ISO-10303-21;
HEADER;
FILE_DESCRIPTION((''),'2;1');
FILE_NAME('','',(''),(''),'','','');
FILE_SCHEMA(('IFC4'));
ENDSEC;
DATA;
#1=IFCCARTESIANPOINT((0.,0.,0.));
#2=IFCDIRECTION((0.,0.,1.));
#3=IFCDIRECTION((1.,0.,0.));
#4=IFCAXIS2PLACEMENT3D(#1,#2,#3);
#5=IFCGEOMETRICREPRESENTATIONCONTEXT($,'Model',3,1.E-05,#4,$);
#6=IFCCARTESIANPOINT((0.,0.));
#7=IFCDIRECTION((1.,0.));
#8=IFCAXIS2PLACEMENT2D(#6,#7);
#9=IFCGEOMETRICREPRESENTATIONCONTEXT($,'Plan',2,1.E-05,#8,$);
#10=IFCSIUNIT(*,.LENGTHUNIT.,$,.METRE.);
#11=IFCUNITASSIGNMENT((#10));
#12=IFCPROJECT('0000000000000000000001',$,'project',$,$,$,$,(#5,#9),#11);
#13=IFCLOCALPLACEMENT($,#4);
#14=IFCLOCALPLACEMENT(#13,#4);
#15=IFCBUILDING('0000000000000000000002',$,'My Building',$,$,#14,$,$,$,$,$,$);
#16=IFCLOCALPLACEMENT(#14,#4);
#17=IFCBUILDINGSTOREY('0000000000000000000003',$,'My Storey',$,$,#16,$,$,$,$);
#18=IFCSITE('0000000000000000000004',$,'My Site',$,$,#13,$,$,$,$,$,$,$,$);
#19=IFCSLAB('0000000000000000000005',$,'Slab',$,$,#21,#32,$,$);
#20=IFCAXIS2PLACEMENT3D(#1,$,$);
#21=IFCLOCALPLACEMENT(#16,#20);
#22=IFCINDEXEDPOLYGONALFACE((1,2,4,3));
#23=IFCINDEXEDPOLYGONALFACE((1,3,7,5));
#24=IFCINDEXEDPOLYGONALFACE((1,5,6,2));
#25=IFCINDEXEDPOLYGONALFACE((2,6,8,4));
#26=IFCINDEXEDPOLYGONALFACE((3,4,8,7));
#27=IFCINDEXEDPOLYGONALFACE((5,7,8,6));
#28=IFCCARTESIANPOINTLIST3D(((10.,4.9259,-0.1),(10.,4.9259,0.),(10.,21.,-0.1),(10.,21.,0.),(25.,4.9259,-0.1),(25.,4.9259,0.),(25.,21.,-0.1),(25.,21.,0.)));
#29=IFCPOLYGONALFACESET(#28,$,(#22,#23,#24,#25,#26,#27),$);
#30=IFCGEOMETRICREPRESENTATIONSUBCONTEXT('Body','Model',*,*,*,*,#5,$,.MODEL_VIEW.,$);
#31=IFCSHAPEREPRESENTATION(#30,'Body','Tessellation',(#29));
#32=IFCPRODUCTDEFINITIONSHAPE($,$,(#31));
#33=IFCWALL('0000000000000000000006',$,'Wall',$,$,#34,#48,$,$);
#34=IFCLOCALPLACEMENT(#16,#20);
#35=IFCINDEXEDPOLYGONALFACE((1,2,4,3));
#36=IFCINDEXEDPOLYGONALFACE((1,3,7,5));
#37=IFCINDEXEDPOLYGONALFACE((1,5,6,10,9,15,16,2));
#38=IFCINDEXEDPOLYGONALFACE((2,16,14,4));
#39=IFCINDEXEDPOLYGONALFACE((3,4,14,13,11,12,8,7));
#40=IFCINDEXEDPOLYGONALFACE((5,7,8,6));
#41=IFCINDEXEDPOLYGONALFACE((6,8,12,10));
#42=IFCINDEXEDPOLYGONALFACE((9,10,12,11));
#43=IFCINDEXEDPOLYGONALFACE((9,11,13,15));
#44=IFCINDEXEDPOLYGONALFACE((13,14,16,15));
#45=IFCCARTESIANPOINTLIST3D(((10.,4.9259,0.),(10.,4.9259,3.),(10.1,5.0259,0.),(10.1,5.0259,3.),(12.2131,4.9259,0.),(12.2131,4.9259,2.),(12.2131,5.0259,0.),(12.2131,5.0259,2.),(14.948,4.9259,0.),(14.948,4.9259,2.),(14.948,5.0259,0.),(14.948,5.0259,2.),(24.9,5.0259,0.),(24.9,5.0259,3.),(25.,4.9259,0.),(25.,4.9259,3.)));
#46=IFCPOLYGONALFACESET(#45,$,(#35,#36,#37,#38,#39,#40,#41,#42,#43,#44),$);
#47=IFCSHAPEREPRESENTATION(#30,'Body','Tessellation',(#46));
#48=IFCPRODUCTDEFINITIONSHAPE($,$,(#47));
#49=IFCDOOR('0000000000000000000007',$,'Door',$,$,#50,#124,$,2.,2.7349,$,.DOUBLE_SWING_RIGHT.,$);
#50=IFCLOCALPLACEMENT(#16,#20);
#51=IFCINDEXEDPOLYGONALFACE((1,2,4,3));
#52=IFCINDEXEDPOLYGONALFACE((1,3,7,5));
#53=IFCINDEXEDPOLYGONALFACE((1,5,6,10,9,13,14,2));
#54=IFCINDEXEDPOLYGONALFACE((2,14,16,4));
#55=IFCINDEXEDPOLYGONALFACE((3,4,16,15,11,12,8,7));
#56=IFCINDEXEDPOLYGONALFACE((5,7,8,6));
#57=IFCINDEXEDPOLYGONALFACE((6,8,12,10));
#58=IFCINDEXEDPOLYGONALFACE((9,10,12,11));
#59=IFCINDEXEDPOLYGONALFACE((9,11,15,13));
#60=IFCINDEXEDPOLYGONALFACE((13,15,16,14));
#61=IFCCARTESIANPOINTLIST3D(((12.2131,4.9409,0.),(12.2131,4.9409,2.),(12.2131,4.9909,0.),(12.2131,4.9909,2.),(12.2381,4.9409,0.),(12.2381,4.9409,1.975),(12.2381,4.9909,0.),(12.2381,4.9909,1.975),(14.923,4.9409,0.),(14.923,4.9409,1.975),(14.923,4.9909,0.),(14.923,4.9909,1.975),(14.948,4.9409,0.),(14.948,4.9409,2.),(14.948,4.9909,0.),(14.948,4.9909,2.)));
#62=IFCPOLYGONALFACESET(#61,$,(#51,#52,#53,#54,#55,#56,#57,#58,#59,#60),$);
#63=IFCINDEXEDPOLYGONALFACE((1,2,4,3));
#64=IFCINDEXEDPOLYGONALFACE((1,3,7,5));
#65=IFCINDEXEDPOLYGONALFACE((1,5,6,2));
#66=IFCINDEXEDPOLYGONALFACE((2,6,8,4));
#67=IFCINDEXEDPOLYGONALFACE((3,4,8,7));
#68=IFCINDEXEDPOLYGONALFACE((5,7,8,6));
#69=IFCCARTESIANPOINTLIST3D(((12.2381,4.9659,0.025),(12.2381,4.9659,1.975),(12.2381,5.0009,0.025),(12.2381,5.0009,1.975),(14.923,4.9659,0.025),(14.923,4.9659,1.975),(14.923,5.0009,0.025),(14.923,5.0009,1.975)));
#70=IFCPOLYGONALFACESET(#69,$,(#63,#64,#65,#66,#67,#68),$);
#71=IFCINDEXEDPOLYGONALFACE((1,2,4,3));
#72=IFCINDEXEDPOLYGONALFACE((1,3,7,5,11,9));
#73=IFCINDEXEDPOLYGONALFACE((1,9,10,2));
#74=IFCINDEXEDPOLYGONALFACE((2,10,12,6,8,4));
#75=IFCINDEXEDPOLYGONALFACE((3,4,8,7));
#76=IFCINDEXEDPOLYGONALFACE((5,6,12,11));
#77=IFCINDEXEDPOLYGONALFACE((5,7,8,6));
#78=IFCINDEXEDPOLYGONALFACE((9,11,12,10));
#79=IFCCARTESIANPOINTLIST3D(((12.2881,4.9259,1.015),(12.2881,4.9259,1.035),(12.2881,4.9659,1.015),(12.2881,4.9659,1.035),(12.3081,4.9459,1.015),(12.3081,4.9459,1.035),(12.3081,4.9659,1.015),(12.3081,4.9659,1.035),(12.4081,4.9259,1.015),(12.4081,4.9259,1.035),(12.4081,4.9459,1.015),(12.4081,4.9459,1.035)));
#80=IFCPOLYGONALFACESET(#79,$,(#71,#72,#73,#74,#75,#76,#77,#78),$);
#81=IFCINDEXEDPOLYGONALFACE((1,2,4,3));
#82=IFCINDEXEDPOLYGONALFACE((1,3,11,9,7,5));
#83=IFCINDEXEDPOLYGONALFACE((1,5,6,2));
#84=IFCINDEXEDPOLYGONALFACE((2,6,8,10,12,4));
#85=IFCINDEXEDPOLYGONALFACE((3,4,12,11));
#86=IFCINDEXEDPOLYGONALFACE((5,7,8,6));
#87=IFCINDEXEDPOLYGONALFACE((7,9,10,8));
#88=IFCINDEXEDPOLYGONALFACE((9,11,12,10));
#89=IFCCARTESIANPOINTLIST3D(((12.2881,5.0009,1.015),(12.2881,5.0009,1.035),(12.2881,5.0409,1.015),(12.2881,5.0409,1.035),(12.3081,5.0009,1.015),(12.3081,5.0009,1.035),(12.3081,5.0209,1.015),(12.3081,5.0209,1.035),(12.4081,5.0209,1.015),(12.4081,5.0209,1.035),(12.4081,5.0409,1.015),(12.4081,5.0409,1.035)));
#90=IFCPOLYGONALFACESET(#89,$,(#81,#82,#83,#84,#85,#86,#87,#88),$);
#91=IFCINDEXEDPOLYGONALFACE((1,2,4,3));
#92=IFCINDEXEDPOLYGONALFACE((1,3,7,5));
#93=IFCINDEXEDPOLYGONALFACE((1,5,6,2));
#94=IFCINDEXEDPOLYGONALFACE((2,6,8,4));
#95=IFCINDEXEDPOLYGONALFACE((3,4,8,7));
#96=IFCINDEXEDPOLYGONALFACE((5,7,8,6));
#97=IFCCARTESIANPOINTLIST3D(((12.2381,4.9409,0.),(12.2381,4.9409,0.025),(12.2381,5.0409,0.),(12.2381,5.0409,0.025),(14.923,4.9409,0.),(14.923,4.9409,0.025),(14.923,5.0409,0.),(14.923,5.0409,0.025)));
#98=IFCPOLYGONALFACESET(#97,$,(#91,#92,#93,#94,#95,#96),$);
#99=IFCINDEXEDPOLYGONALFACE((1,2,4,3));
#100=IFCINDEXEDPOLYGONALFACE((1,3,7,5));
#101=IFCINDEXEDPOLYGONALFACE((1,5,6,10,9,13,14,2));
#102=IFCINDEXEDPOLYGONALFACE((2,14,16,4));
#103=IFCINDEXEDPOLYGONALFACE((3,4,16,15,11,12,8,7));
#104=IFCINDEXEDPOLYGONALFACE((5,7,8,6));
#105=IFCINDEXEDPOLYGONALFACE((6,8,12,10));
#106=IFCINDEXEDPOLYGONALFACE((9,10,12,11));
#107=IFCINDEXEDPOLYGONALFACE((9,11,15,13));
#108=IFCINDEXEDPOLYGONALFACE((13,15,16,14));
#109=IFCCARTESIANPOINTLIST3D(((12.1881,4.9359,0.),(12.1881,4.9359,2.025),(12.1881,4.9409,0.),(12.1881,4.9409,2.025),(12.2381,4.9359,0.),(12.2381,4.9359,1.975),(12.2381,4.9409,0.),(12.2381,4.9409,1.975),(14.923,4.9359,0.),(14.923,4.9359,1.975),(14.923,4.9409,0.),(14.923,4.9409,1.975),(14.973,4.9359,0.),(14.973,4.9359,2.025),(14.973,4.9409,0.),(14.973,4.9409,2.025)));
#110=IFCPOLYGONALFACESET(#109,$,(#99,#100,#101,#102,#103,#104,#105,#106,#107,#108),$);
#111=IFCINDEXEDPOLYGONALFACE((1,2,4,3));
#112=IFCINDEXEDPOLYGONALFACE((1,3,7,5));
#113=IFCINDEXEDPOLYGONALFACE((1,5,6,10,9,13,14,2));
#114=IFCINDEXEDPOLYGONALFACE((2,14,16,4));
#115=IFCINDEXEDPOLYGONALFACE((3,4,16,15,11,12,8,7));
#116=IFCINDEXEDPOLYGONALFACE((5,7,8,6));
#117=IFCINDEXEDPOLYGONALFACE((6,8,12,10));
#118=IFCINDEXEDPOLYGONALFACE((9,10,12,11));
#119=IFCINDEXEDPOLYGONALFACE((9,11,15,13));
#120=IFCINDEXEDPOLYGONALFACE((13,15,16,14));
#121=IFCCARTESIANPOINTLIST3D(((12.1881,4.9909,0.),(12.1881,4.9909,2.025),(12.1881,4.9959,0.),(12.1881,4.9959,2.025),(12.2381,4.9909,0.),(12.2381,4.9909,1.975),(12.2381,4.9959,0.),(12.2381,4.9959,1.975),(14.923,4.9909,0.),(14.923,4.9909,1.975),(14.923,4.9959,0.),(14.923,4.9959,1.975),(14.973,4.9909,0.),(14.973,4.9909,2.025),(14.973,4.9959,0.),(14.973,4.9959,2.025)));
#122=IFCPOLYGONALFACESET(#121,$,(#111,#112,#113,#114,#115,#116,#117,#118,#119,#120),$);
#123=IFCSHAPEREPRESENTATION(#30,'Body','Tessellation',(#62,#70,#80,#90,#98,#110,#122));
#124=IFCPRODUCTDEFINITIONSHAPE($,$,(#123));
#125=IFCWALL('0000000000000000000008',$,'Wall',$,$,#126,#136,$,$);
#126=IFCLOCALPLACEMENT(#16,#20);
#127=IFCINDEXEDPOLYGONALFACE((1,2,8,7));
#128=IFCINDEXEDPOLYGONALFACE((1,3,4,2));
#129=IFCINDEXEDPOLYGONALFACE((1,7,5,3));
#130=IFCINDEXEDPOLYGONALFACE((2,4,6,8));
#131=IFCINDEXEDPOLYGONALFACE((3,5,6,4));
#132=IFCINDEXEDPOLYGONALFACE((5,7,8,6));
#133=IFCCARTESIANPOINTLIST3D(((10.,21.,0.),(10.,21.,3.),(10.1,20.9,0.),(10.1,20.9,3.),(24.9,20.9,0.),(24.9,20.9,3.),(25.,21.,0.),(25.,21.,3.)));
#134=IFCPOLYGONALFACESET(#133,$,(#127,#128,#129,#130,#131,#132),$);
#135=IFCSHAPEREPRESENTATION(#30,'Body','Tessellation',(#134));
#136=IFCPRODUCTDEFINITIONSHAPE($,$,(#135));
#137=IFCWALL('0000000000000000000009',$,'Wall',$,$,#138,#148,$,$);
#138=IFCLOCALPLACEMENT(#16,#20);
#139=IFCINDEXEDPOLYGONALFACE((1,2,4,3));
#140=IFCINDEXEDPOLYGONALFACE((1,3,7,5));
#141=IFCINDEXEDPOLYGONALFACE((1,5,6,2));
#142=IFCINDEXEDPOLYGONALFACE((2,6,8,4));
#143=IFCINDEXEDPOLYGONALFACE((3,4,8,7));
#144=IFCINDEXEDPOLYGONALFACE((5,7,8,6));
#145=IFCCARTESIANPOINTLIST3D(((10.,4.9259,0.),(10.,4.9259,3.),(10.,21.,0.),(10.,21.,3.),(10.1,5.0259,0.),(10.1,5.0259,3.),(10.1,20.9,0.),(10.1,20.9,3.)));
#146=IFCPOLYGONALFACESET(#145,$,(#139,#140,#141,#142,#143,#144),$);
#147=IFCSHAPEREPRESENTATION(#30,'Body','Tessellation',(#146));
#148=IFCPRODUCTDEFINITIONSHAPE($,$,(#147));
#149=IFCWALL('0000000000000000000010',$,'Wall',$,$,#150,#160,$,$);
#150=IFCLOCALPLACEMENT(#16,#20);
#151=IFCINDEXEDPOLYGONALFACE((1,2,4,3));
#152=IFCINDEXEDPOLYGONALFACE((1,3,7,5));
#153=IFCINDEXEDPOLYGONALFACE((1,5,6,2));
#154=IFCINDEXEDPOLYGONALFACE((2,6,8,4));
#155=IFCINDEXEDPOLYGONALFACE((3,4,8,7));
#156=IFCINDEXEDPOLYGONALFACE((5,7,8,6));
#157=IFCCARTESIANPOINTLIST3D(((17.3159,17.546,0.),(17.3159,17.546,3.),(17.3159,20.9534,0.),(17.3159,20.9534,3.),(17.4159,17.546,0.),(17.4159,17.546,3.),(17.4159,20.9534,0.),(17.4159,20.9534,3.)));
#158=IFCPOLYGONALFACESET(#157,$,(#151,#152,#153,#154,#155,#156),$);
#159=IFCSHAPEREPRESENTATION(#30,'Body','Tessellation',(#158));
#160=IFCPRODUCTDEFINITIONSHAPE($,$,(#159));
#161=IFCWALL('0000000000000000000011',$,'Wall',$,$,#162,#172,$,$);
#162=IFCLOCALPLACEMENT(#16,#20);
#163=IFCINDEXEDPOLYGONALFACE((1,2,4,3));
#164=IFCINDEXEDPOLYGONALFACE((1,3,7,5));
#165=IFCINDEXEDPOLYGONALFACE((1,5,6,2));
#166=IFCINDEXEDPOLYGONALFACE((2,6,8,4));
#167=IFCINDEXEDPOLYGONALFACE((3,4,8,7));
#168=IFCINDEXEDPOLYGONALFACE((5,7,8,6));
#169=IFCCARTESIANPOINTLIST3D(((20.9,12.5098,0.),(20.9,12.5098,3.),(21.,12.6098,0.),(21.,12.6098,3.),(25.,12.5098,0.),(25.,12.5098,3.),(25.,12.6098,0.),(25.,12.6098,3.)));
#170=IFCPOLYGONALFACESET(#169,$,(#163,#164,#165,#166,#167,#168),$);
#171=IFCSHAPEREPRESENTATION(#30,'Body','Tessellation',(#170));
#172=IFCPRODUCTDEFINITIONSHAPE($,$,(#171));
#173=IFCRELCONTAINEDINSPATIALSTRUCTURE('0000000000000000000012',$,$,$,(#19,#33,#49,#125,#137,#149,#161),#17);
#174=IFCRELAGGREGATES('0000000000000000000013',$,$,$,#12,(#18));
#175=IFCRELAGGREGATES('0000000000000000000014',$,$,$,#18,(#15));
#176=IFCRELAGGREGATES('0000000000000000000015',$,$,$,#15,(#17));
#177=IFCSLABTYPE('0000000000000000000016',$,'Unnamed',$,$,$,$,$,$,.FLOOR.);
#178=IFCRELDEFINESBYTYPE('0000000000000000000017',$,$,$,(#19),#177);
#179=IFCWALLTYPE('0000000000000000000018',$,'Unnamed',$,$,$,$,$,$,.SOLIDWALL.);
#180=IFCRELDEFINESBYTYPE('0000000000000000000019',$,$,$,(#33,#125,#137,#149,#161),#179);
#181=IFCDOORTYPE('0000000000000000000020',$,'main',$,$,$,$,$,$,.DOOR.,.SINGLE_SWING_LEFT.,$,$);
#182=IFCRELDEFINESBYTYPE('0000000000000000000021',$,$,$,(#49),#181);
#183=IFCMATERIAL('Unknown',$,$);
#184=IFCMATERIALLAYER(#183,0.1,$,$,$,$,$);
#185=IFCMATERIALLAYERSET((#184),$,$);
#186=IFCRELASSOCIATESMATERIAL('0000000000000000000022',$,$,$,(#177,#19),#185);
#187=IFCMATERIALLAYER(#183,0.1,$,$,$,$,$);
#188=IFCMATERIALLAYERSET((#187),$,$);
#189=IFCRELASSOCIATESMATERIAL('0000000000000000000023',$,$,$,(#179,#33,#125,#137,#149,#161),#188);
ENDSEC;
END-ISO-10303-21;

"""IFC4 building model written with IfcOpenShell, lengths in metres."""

from ifc_helpers import new_model, entity, si_unit, frame, origin_with_axes, origin_2d_with_axis, place, context, subcontext, project, spatial, line, indexed_curve, outline, extrude, shape, source, transform, mapped, material, layer, layer_set, layer_usage, type_object, type_shapes, element, fill, save


model = new_model("IFC4")

# Units and contexts
model_context = context("Model", 3, precision=1e-05, world=origin_with_axes())
plan_context = context("Plan", 2, precision=1e-05, world=origin_2d_with_axis())
body_context_1 = subcontext(model_context, "Body", "Model", "MODEL_VIEW")
body_context_2 = subcontext(plan_context, "Body", "Plan", "PLAN_VIEW")
ifc_project = project(units=[si_unit("LENGTHUNIT", "METRE")], contexts=[model_context, plan_context])

# Site, building, storey
site_placement = place(None, origin_with_axes())
site = spatial("IfcSite", under=ifc_project, at=site_placement, Name="My Site")
building_placement = place(site_placement, origin_with_axes())
building = spatial("IfcBuilding", under=site, at=building_placement, Name="My Building")
storey_placement = place(building_placement, origin_with_axes())
storey = spatial("IfcBuildingStorey", under=building, at=storey_placement, Name="My Storey")

# Slab
ifc_material = material(Name="Unknown")
ifc_layer_1 = layer(ifc_material, 0.1)
ifc_layer_set_1 = layer_set([ifc_layer_1])
ifc_layer_usage_1 = layer_usage(ifc_layer_set_1, "AXIS3", "POSITIVE", -0.1)
slab_type = type_object("IfcSlabType", Name="Unnamed", PredefinedType="FLOOR", material=ifc_layer_set_1)
slab_placement = place(storey_placement, frame((10.0, 21.0, 0.0), z_axis=(0.0, 0.0, 1.0), x_axis=(1.0, 0.0, 0.0)))
element("IfcSlab", 1, at=slab_placement, inside=storey, type_object=slab_type, material=ifc_layer_usage_1, Name="Slab", context=body_context_1, shape_type="SweptSolid", body=[
    extrude(outline(indexed_curve([(0.0, -16.0741), (15.0, -16.0741), (15.0, 0.0), (0.0, 0.0), (0.0, -16.0741)])), frame((0.0, 0.0, -0.1), z_axis=(0.0, 0.0, 1.0), x_axis=(1.0, 0.0, 0.0)), (0.0, 0.0, 1.0), 0.1),
])

# Wall, opening, door
ifc_layer_2 = layer(ifc_material, 0.1)
ifc_layer_set_2 = layer_set([ifc_layer_2])
ifc_layer_usage_2 = layer_usage(ifc_layer_set_2, "AXIS2", "POSITIVE", 0.0)
wall_type = type_object("IfcWallType", Name="Unnamed", PredefinedType="SOLIDWALL", material=ifc_layer_set_2)
wall_1_placement = place(storey_placement, frame((10.0, 4.9259, 0.0), z_axis=(0.0, 0.0, 1.0), x_axis=(1.0, 0.0, 0.0)))
wall_1 = element("IfcWall", 2, at=wall_1_placement, inside=storey, type_object=wall_type, material=ifc_layer_usage_2, Name="Wall", context=body_context_1, shape_type="SweptSolid", body=[
    extrude(outline(indexed_curve([(0.0, 0.0), (0.1, 0.1), (14.9, 0.1), (15.0, 0.0)], segments=[line(1, 2, 3, 4, 1)])), origin_with_axes(), (0.0, 0.0, 1.0), 3.0),
])
shared_shape_1 = source(origin_with_axes(), body_context_1, "Body", "SweptSolid", [
    extrude(outline(indexed_curve([(0.0, 0.0), (2.7349, 0.0), (2.7349, 2.0), (0.0, 2.0)], segments=[line(1, 2, 3, 4, 1)])), frame((0.0, -0.6, 0.0), z_axis=(0.0, -1.0, 0.0), x_axis=(1.0, 0.0, 0.0)), (0.0, 0.0, -1.0), 1.2),
])
opening_1_placement = place(wall_1_placement, frame((2.2131, 0.015, 0.0), z_axis=(0.0, 0.0, 1.0), x_axis=(1.0, 0.0, 0.0)))
opening_1 = element("IfcOpeningElement", 3, at=opening_1_placement, cuts=wall_1, PredefinedType="OPENING", context=body_context_1, shape_type="MappedRepresentation", body=[
    mapped(shared_shape_1, transform((0.0, 0.0, 0.0), x_axis=(1.0, 0.0, 0.0), y_axis=(0.0, 1.0, 0.0), z_axis=(0.0, 0.0, 1.0), scale=1.0)),
])
door_type_1 = type_object("IfcDoorType", Name="main", OperationType="SINGLE_SWING_LEFT", PredefinedType="DOOR")
shared_shape_2 = source(origin_with_axes(), body_context_1, "Body", "SweptSolid", [
    extrude(outline(indexed_curve([(0.0, 0.0), (0.0, 2.0), (2.7349, 2.0), (2.7349, 0.0), (2.7099, 0.0), (2.7099, 1.975), (0.025, 1.975), (0.025, 0.0)], segments=[line(1, 2, 3, 4, 5, 6, 7, 8, 1)])), frame((0.0, 0.0, 0.0), z_axis=(0.0, -1.0, 0.0), x_axis=(1.0, 0.0, 0.0)), (0.0, 0.0, -1.0), 0.05),
    extrude(outline(indexed_curve([(0.0, 0.0), (2.6849, 0.0), (2.6849, 0.035), (0.0, 0.035)], segments=[line(1, 2, 3, 4, 1)])), frame((0.025, 0.025, 0.025), z_axis=(0.0, 0.0, 1.0), x_axis=(1.0, 0.0, 0.0)), (0.0, 0.0, 1.0), 1.95),
    extrude(outline(indexed_curve([(0.0, 0.0), (0.0, -0.04), (0.12, -0.04), (0.12, -0.02), (0.02, -0.02), (0.02, 0.0)], segments=[line(1, 2, 3, 4, 5, 6, 1)])), frame((0.075, 0.025, 1.015), z_axis=(0.0, 0.0, 1.0), x_axis=(1.0, 0.0, 0.0)), (0.0, 0.0, 1.0), 0.02),
    extrude(outline(indexed_curve([(0.0, 0.0), (0.0, 0.04), (0.12, 0.04), (0.12, 0.02), (0.02, 0.02), (0.02, 0.0)], segments=[line(1, 2, 3, 4, 5, 6, 1)])), frame((0.075, 0.06, 1.015), z_axis=(0.0, 0.0, 1.0), x_axis=(1.0, 0.0, 0.0)), (0.0, 0.0, 1.0), 0.02),
    extrude(outline(indexed_curve([(0.0, 0.0), (2.6849, 0.0), (2.6849, 0.1), (0.0, 0.1)], segments=[line(1, 2, 3, 4, 1)])), frame((0.025, 0.0, 0.0), z_axis=(0.0, 0.0, 1.0), x_axis=(1.0, 0.0, 0.0)), (0.0, 0.0, 1.0), 0.025),
    extrude(outline(indexed_curve([(0.0, 0.0), (0.0, 2.025), (2.7849, 2.025), (2.7849, 0.0), (2.7349, 0.0), (2.7349, 1.975), (0.05, 1.975), (0.05, 0.0)], segments=[line(1, 2, 3, 4, 5, 6, 7, 8, 1)])), frame((-0.025, -0.005, 0.0), z_axis=(0.0, -1.0, 0.0), x_axis=(1.0, 0.0, 0.0)), (0.0, 0.0, -1.0), 0.005),
    extrude(outline(indexed_curve([(0.0, 0.0), (0.0, 2.025), (2.7849, 2.025), (2.7849, 0.0), (2.7349, 0.0), (2.7349, 1.975), (0.05, 1.975), (0.05, 0.0)], segments=[line(1, 2, 3, 4, 5, 6, 7, 8, 1)])), frame((-0.025, 0.05, 0.0), z_axis=(0.0, -1.0, 0.0), x_axis=(1.0, 0.0, 0.0)), (0.0, 0.0, -1.0), 0.005),
])
shared_shape_3 = source(origin_with_axes(), body_context_2, "Body", "Curve2D", [
    entity("IfcIndexedPolyCurve", entity("IfcCartesianPointList2D", [[0.0, 0.0], [0.025, 0.0], [0.025, 0.05], [0.0, 0.05]]), [entity("IfcLineIndex", [1, 2, 3, 4, 1])]),
    entity("IfcIndexedPolyCurve", entity("IfcCartesianPointList2D", [[2.7349, 0.0], [2.7099, 0.0], [2.7099, 0.05], [2.7349, 0.05]]), [entity("IfcLineIndex", [1, 2, 3, 4, 1])]),
    entity("IfcIndexedPolyCurve", entity("IfcCartesianPointList2D", [[2.7099, 0.05], [2.7099, -2.6349], [2.6749, -2.6349]])),
    entity("IfcTrimmedCurve", entity("IfcEllipse", entity("IfcAxis2Placement2D", entity("IfcCartesianPoint", [2.6749, 0.05]), entity("IfcDirection", [1.0, 0.0])), 2.6499, 2.6849), [entity("IfcCartesianPoint", [2.6749, 2.7349])], [entity("IfcCartesianPoint", [2.6749, -2.6349])], True, "CARTESIAN"),
    entity("IfcIndexedPolyCurve", entity("IfcCartesianPointList2D", [[2.7099, 0.05], [2.6749, 0.05], [2.6749, 2.7349], [2.7099, 2.7349]]), [entity("IfcLineIndex", [1, 2, 3, 4, 1])]),
])
type_shapes(door_type_1, [shared_shape_2, shared_shape_3])
door_1_placement = place(opening_1_placement, frame((0.0, 0.0, 0.0), z_axis=(0.0, 0.0, 1.0), x_axis=(1.0, 0.0, 0.0)))
door_1 = element("IfcDoor", 4, at=door_1_placement, inside=storey, type_object=door_type_1, Name="Door", OperationType="DOUBLE_SWING_RIGHT", OverallHeight=2.0, OverallWidth=2.7349, shapes=[
    shape(body_context_1, "Body", "MappedRepresentation", [mapped(shared_shape_2, transform((0.0, 0.0, 0.0), x_axis=(1.0, 0.0, 0.0), y_axis=(0.0, 1.0, 0.0), z_axis=(0.0, 0.0, 1.0), scale=1.0))]),
    shape(body_context_2, "Body", "MappedRepresentation", [mapped(shared_shape_3, transform((0.0, 0.0, 0.0), x_axis=(1.0, 0.0, 0.0), y_axis=(0.0, 1.0, 0.0), z_axis=(0.0, 0.0, 1.0), scale=1.0))]),
])
fill(opening_1, door_1)

# Walls
ifc_layer_usage_3 = layer_usage(ifc_layer_set_2, "AXIS2", "POSITIVE", 0.0)
wall_2_placement = place(storey_placement, frame((25.0, 21.0, 0.0), z_axis=(0.0, 0.0, 1.0), x_axis=(-1.0, 0.0, 0.0)))
element("IfcWall", 5, at=wall_2_placement, inside=storey, type_object=wall_type, material=ifc_layer_usage_3, Name="Wall", context=body_context_1, shape_type="SweptSolid", body=[
    extrude(outline(indexed_curve([(0.0, 0.0), (0.1, 0.1), (14.9, 0.1), (15.0, 0.0)], segments=[line(1, 2, 3, 4, 1)])), origin_with_axes(), (0.0, 0.0, 1.0), 3.0),
])
ifc_layer_usage_4 = layer_usage(ifc_layer_set_2, "AXIS2", "POSITIVE", 0.0)
wall_3_placement = place(storey_placement, frame((10.0, 21.0, 0.0), z_axis=(0.0, 0.0, 1.0), x_axis=(0.0, -1.0, 0.0)))
element("IfcWall", 6, at=wall_3_placement, inside=storey, type_object=wall_type, material=ifc_layer_usage_4, Name="Wall", context=body_context_1, shape_type="SweptSolid", body=[
    extrude(outline(indexed_curve([(0.0, 0.0), (0.1, 0.1), (15.9741, 0.1), (16.0741, 0.0)], segments=[line(1, 2, 3, 4, 1)])), origin_with_axes(), (0.0, 0.0, 1.0), 3.0),
])

# Walls
ifc_layer_usage_5 = layer_usage(ifc_layer_set_2, "AXIS2", "POSITIVE", 0.0)
wall_4_placement = place(storey_placement, frame((17.3159, 20.9534, 0.0), z_axis=(0.0, 0.0, 1.0), x_axis=(0.0, -1.0, 0.0)))
element("IfcWall", 7, at=wall_4_placement, inside=storey, type_object=wall_type, material=ifc_layer_usage_5, Name="Wall", context=body_context_1, shape_type="SweptSolid", body=[
    extrude(outline(indexed_curve([(0.0, 0.0), (0.0, 0.1), (3.4073, 0.1), (3.4073, 0.0)], segments=[line(1, 2, 3, 4, 1)])), origin_with_axes(), (0.0, 0.0, 1.0), 3.0),
])
ifc_layer_usage_6 = layer_usage(ifc_layer_set_2, "AXIS2", "POSITIVE", 0.0)
wall_5_placement = place(storey_placement, frame((25.0, 12.6098, 0.0), z_axis=(0.0, 0.0, 1.0), x_axis=(-1.0, 0.0, 0.0)))
element("IfcWall", 8, at=wall_5_placement, inside=storey, type_object=wall_type, material=ifc_layer_usage_6, Name="Wall", context=body_context_1, shape_type="SweptSolid", body=[
    extrude(outline(indexed_curve([(0.0, 0.0), (0.0, 0.1), (4.1, 0.1), (4.0, 0.0)], segments=[line(1, 2, 3, 4, 1)])), origin_with_axes(), (0.0, 0.0, 1.0), 3.0),
])

save(model, "model.ifc")
